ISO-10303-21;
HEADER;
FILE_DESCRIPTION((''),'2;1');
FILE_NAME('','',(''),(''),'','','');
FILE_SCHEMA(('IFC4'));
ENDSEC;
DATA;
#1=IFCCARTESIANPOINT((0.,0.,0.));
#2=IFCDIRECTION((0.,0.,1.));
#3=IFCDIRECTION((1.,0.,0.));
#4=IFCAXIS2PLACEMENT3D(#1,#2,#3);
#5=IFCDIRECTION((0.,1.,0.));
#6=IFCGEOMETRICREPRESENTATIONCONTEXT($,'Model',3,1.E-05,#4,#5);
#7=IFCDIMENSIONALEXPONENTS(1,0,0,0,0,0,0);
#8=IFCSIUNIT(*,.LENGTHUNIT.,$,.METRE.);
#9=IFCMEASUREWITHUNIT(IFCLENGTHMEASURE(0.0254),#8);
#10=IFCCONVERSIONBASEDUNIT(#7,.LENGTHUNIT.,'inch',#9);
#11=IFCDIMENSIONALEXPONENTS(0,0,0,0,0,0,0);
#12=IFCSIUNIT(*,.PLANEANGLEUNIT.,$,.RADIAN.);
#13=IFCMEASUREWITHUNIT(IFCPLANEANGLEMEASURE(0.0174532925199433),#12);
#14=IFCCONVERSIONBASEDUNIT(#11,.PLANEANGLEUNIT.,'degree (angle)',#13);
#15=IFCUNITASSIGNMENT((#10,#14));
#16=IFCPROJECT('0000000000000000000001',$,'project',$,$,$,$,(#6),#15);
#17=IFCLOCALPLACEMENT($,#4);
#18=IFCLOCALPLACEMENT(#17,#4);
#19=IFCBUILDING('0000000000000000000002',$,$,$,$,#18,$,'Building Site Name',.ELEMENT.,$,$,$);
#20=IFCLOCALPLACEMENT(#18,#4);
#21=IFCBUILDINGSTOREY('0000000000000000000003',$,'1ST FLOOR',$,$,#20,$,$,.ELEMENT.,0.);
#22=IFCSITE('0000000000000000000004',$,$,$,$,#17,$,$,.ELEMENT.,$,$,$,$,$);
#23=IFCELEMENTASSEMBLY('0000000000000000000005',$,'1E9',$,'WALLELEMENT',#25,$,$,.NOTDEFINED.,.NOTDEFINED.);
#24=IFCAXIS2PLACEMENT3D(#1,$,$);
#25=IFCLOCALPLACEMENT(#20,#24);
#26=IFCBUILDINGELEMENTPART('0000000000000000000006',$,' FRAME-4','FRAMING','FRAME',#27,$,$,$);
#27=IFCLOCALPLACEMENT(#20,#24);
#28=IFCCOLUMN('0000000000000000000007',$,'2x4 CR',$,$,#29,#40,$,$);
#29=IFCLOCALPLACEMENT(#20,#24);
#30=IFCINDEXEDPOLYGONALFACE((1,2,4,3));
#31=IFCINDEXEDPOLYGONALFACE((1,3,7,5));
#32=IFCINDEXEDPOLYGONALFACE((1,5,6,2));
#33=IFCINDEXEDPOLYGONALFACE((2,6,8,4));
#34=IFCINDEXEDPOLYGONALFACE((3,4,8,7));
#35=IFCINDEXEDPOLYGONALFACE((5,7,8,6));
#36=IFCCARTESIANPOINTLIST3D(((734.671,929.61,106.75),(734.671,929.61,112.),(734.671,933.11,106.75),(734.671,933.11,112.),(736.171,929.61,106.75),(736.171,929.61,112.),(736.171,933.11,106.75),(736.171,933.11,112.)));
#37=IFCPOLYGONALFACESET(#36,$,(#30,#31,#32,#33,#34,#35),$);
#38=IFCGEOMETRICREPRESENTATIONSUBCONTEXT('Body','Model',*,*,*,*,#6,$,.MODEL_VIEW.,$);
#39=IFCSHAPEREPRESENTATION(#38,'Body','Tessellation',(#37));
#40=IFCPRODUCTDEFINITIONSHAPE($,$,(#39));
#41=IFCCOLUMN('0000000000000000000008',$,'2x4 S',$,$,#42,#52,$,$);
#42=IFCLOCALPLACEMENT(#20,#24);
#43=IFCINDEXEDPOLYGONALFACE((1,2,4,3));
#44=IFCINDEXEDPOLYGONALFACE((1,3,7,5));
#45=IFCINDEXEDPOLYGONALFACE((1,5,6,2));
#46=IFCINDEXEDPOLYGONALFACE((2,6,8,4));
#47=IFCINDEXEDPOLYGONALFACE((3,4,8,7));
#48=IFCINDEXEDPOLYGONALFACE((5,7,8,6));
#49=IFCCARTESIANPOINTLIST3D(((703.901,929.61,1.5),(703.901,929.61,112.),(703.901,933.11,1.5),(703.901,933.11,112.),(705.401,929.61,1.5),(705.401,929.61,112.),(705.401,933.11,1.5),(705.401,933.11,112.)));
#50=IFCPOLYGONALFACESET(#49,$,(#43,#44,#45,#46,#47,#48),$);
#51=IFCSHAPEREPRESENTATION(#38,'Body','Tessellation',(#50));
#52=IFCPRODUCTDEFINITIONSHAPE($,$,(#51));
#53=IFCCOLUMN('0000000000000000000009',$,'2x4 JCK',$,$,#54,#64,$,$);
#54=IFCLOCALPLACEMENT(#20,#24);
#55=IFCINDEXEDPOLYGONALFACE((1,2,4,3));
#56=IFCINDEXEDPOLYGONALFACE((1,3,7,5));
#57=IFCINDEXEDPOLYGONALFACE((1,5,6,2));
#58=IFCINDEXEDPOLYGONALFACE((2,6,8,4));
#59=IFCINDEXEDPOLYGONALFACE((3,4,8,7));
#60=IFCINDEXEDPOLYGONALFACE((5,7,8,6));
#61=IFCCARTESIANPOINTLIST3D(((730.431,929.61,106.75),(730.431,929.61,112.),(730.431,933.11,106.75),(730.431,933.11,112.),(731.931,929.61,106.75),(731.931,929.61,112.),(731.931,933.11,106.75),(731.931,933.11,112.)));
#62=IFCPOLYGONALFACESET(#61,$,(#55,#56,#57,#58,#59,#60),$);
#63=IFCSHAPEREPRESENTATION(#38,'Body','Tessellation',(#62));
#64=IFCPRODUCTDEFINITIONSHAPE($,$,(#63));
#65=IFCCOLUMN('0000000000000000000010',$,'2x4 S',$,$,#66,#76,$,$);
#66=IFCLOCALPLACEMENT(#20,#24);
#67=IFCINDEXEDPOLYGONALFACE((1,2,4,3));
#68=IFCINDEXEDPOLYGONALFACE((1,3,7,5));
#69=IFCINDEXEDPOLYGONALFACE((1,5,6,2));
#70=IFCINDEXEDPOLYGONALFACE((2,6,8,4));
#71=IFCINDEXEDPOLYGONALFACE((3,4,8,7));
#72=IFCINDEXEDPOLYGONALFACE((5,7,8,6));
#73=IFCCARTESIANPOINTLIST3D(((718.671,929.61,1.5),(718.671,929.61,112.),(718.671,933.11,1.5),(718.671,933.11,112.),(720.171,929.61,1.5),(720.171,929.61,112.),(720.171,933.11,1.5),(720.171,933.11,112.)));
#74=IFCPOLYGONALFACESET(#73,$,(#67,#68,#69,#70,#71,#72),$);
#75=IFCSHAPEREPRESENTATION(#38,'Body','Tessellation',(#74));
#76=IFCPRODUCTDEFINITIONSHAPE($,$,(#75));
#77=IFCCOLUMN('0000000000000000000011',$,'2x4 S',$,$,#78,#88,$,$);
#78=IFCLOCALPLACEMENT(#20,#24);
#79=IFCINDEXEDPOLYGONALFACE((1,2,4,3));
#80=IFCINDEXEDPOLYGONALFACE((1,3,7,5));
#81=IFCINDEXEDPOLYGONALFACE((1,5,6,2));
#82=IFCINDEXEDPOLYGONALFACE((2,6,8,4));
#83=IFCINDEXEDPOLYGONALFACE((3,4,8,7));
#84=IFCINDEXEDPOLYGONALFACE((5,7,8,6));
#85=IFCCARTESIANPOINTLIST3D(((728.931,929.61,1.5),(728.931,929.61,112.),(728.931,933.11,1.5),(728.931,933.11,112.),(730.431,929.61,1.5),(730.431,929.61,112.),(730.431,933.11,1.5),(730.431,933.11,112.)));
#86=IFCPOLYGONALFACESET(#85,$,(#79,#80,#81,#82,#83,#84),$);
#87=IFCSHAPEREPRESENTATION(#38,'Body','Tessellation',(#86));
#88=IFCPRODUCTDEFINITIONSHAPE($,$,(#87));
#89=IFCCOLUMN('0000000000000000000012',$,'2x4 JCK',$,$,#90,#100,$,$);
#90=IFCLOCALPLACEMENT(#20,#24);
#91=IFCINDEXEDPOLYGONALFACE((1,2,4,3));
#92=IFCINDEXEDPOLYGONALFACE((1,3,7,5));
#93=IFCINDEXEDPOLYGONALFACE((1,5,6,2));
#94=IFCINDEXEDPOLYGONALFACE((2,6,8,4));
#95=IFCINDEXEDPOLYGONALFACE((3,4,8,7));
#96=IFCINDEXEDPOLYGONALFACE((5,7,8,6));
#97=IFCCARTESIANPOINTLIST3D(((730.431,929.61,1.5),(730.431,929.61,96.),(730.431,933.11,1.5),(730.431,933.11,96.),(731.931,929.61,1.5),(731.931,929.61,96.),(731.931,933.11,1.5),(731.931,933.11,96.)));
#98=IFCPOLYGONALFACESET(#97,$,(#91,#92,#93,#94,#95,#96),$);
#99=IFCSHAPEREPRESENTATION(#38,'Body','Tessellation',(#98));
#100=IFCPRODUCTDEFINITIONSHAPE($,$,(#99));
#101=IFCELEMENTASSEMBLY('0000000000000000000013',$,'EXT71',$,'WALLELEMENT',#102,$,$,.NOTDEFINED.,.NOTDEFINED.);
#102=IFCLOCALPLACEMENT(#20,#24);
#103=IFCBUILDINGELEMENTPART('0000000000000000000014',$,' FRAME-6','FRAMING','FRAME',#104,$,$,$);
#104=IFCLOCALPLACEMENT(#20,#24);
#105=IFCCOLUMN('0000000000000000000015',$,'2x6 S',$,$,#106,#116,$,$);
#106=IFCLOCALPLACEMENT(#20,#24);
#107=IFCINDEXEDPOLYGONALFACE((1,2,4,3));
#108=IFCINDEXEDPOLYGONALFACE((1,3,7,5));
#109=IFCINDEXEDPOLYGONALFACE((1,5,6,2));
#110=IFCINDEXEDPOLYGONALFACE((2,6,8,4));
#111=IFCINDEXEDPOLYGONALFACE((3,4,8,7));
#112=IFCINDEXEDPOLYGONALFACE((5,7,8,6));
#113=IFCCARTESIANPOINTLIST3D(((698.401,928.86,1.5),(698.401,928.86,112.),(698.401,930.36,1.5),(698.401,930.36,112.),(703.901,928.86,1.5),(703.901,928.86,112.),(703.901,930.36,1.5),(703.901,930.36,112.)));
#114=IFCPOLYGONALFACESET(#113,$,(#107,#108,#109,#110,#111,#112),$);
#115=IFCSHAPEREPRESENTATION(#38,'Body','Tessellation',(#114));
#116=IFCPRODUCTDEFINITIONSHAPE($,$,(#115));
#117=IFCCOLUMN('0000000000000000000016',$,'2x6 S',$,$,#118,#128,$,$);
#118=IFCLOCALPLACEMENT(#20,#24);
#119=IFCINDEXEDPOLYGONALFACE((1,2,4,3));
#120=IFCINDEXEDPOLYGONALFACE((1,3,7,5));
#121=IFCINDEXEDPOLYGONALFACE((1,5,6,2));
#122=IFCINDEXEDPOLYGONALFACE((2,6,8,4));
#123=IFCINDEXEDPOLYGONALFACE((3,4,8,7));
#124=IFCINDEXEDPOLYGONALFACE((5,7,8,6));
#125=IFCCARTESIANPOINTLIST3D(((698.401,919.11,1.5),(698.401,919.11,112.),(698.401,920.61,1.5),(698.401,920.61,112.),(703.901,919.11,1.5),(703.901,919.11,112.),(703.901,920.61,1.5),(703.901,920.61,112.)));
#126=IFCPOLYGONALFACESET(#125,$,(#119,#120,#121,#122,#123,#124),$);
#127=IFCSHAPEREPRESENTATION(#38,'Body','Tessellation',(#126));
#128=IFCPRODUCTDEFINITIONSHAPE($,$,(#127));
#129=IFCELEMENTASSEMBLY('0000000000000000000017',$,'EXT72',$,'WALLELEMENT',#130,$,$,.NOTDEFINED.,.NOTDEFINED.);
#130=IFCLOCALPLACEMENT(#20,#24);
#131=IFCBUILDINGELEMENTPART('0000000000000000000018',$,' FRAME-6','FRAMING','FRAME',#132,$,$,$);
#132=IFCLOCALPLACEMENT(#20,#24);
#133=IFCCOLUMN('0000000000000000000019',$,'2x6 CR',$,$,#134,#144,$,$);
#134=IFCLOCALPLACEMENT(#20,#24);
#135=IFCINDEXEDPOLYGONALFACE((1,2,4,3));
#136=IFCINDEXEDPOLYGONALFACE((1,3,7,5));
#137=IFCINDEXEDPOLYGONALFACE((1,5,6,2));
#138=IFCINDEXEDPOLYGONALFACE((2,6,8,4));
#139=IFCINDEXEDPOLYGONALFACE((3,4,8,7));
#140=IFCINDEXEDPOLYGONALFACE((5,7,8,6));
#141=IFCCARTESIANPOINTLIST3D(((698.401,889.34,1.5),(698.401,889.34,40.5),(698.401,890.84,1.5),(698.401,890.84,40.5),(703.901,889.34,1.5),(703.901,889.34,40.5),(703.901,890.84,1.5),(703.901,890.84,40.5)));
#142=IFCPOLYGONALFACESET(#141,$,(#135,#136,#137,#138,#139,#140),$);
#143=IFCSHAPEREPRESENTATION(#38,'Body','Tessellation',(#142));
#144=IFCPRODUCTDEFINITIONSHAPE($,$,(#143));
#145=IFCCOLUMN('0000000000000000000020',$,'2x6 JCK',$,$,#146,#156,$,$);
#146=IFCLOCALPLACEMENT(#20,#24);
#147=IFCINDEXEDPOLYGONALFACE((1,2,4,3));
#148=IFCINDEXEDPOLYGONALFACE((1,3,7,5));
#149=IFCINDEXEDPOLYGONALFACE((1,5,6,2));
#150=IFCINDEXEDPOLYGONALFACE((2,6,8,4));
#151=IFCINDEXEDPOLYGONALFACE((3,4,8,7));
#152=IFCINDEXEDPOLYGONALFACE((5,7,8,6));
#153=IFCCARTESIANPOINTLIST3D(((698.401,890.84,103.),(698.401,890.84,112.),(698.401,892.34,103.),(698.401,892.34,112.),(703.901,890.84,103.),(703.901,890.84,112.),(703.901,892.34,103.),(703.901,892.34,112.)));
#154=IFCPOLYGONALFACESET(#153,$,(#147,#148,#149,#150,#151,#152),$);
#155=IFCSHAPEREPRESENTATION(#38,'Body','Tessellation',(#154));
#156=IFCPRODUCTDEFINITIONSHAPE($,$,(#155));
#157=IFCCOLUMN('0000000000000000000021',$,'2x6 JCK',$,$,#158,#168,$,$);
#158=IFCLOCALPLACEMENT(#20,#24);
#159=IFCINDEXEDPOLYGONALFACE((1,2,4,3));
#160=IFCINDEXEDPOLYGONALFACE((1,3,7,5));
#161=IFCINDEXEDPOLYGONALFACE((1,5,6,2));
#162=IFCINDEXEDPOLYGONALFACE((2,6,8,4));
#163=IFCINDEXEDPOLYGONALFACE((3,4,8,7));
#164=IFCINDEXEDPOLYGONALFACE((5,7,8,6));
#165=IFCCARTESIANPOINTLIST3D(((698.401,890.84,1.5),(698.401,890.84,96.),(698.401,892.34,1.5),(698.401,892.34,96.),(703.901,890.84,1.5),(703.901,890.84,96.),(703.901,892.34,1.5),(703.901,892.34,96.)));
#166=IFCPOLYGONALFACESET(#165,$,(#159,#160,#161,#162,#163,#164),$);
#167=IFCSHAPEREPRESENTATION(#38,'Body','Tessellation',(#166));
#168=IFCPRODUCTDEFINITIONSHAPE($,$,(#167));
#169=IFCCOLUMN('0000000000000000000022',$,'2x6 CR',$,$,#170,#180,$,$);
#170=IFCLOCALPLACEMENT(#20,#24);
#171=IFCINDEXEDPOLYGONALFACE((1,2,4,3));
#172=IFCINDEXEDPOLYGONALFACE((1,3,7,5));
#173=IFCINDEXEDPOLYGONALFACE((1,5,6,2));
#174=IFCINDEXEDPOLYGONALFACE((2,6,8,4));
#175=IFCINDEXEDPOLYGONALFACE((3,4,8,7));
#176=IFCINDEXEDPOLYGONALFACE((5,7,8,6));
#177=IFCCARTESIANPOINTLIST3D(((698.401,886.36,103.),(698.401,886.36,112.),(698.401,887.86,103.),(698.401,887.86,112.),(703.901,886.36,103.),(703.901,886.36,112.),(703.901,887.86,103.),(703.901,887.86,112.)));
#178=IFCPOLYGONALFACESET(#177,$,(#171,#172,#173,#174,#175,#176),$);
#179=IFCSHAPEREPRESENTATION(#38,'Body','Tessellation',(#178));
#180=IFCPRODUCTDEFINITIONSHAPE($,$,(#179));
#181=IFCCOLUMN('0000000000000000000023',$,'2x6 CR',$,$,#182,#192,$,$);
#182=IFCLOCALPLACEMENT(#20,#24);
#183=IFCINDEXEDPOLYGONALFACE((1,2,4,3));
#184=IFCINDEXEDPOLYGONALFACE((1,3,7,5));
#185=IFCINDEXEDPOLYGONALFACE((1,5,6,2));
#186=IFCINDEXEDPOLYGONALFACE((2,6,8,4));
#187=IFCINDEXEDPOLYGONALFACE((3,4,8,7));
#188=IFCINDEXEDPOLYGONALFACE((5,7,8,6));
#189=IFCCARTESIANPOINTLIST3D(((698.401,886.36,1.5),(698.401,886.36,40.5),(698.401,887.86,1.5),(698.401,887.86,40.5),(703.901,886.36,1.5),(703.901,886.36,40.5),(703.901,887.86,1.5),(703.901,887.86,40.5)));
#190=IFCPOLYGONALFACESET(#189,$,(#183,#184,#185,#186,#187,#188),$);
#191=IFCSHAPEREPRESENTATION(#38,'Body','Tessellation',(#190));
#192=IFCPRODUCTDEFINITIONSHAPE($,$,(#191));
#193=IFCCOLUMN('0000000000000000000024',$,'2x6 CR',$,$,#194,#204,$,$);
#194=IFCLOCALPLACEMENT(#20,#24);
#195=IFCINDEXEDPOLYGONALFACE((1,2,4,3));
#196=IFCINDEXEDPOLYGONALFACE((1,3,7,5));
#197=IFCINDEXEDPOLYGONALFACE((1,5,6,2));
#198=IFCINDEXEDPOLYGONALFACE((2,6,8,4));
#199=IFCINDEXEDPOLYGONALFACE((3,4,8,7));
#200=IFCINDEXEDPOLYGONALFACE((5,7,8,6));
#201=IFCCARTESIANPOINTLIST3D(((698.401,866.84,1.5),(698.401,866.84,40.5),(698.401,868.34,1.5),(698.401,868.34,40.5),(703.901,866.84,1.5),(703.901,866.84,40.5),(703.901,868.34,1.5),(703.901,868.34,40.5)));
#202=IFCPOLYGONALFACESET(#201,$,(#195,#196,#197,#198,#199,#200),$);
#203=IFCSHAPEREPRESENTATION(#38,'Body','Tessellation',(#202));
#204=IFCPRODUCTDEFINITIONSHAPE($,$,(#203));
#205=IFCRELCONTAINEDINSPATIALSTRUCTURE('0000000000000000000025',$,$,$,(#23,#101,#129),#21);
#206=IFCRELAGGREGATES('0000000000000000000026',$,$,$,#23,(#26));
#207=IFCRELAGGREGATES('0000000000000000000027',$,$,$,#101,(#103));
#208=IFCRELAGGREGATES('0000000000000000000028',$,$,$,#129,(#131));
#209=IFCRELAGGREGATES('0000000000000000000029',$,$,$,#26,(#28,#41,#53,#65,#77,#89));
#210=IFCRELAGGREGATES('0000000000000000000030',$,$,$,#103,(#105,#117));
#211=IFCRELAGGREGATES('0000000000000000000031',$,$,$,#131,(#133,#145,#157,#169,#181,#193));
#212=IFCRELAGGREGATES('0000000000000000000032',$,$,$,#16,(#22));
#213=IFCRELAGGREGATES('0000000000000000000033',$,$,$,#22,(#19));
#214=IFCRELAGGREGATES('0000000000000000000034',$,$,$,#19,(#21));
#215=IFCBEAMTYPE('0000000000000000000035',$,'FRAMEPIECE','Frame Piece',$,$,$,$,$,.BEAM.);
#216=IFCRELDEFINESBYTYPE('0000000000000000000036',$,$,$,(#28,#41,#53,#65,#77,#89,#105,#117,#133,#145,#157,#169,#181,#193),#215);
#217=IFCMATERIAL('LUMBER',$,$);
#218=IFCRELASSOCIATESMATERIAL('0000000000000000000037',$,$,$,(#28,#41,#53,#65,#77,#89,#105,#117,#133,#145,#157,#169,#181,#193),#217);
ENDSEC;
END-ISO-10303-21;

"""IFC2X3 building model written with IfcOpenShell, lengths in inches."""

from ifc_helpers import new_model, entity, si_unit, converted_unit, direction, frame, frame_2d, origin_with_axes, place, context, subcontext, project, spatial, rectangle, extrude, material, type_object, element, aggregate, save


model = new_model("IFC2X3")

# Units and contexts
model_context = context("Model", 3, precision=1e-05, world=origin_with_axes(), true_north=direction((0.0, 1.0, 0.0)))
body_context = subcontext(model_context, "Body", "Model", "MODEL_VIEW")
ifc_project = project(units=[converted_unit("LENGTHUNIT", "inch", entity("IfcLengthMeasure", 0.0254), si_unit("LENGTHUNIT", "METRE"), dimensions=[1, 0, 0, 0, 0, 0, 0]), converted_unit("PLANEANGLEUNIT", "degree (angle)", entity("IfcPlaneAngleMeasure", 0.0174532925199433), si_unit("PLANEANGLEUNIT", "RADIAN"), dimensions=[0, 0, 0, 0, 0, 0, 0])], contexts=[model_context])

# Site, building, storey
site_placement = place(None, origin_with_axes())
site = spatial("IfcSite", under=ifc_project, at=site_placement, CompositionType="ELEMENT")
building_placement = place(site_placement, origin_with_axes())
building = spatial("IfcBuilding", under=site, at=building_placement, LongName="Building Site Name", CompositionType="ELEMENT")
storey_placement = place(building_placement, origin_with_axes())
storey = spatial("IfcBuildingStorey", under=building, at=storey_placement, Name="1ST FLOOR", CompositionType="ELEMENT", Elevation=0.0)

# Element assemblies, building element parts, columns
assembly_1_placement = place(storey_placement, origin_with_axes())
assembly_1 = element("IfcElementAssembly", 1, at=assembly_1_placement, inside=storey, Name="1E9", ObjectType="WALLELEMENT", AssemblyPlace="NOTDEFINED", PredefinedType="NOTDEFINED")
building_element_part_1 = element("IfcBuildingElementPart", 2, Name=" FRAME-4", Description="FRAMING", ObjectType="FRAME")
aggregate(assembly_1, [building_element_part_1])
ifc_material_1 = material(Name="LUMBER")
beam_type = type_object("IfcBeamType", Name="FRAMEPIECE", Description="Frame Piece", PredefinedType="BEAM")
column_1_placement = place(assembly_1_placement, frame((735.421, 931.36, 112.0), z_axis=(0.0, 0.0, -1.0), x_axis=(-1.0, 0.0, 0.0)))
column_1 = element("IfcColumn", 3, at=column_1_placement, type_object=beam_type, material=ifc_material_1, Name="2x4 CR", context=body_context, shape_type="SweptSolid", body=[
    extrude(rectangle(XDim=1.5, YDim=3.5, at=frame_2d((0.0, 0.0), x_axis=(-1.0, 0.0))), origin_with_axes(), (0.0, 0.0, 1.0), 5.25),
])
column_2_placement = place(assembly_1_placement, frame((704.651, 931.36, 1.5), z_axis=(0.0, 0.0, 1.0), x_axis=(1.0, 0.0, 0.0)))
column_2 = element("IfcColumn", 4, at=column_2_placement, type_object=beam_type, material=ifc_material_1, Name="2x4 S", context=body_context, shape_type="SweptSolid", body=[
    extrude(rectangle(XDim=1.5, YDim=3.5, at=frame_2d((0.0, 0.0), x_axis=(-1.0, 0.0))), frame((0.0, 0.0, 0.0), z_axis=(0.0, 0.0, 1.0), x_axis=(1.0, 0.0, 0.0)), (0.0, 0.0, 1.0), 110.5),
])
column_3_placement = place(assembly_1_placement, frame((731.181, 931.36, 106.75), z_axis=(0.0, 0.0, 1.0), x_axis=(1.0, 0.0, 0.0)))
column_3 = element("IfcColumn", 5, at=column_3_placement, type_object=beam_type, material=ifc_material_1, Name="2x4 JCK", context=body_context, shape_type="SweptSolid", body=[
    extrude(rectangle(XDim=1.5, YDim=3.5, at=frame_2d((0.0, 0.0), x_axis=(-1.0, 0.0))), origin_with_axes(), (0.0, 0.0, 1.0), 5.25),
])
column_4_placement = place(assembly_1_placement, frame((719.421, 931.36, 112.0), z_axis=(0.0, 0.0, -1.0), x_axis=(-1.0, 0.0, 0.0)))
column_4 = element("IfcColumn", 6, at=column_4_placement, type_object=beam_type, material=ifc_material_1, Name="2x4 S", context=body_context, shape_type="SweptSolid", body=[
    extrude(rectangle(XDim=1.5, YDim=3.5, at=frame_2d((0.0, 0.0), x_axis=(-1.0, 0.0))), origin_with_axes(), (0.0, 0.0, 1.0), 110.5),
])
column_5_placement = place(assembly_1_placement, frame((729.681, 931.36, 1.5), z_axis=(0.0, 0.0, 1.0), x_axis=(1.0, 0.0, 0.0)))
column_5 = element("IfcColumn", 7, at=column_5_placement, type_object=beam_type, material=ifc_material_1, Name="2x4 S", context=body_context, shape_type="SweptSolid", body=[
    extrude(rectangle(XDim=1.5, YDim=3.5, at=frame_2d((0.0, 0.0), x_axis=(-1.0, 0.0))), frame((0.0, 0.0, 0.0), z_axis=(0.0, 0.0, 1.0), x_axis=(1.0, 0.0, 0.0)), (0.0, 0.0, 1.0), 110.5),
])
column_6_placement = place(assembly_1_placement, frame((731.181, 931.36, 1.5), z_axis=(0.0, 0.0, 1.0), x_axis=(1.0, 0.0, 0.0)))
column_6 = element("IfcColumn", 8, at=column_6_placement, type_object=beam_type, material=ifc_material_1, Name="2x4 JCK", context=body_context, shape_type="SweptSolid", body=[
    extrude(rectangle(XDim=1.5, YDim=3.5, at=frame_2d((0.0, 0.0), x_axis=(-1.0, 0.0))), frame((0.0, 0.0, 0.0), z_axis=(0.0, 0.0, 1.0), x_axis=(1.0, 0.0, 0.0)), (0.0, 0.0, 1.0), 94.5),
])
assembly_2_placement = place(storey_placement, origin_with_axes())
assembly_2 = element("IfcElementAssembly", 9, at=assembly_2_placement, inside=storey, Name="EXT71", ObjectType="WALLELEMENT", AssemblyPlace="NOTDEFINED", PredefinedType="NOTDEFINED")
building_element_part_2 = element("IfcBuildingElementPart", 10, Name=" FRAME-6", Description="FRAMING", ObjectType="FRAME")
aggregate(assembly_2, [building_element_part_2])
column_7_placement = place(assembly_2_placement, frame((701.151, 929.61, 112.0), z_axis=(0.0, 0.0, -1.0), x_axis=(0.0, -1.0, 0.0)))
column_7 = element("IfcColumn", 11, at=column_7_placement, type_object=beam_type, material=ifc_material_1, Name="2x6 S", context=body_context, shape_type="SweptSolid", body=[
    extrude(rectangle(XDim=1.5, YDim=5.5, at=frame_2d((0.0, 0.0), x_axis=(-1.0, 0.0))), origin_with_axes(), (0.0, 0.0, 1.0), 110.5),
])
column_8_placement = place(assembly_2_placement, frame((701.151, 919.86, 1.5), z_axis=(0.0, 0.0, 1.0), x_axis=(0.0, 1.0, 0.0)))
column_8 = element("IfcColumn", 12, at=column_8_placement, type_object=beam_type, material=ifc_material_1, Name="2x6 S", context=body_context, shape_type="SweptSolid", body=[
    extrude(rectangle(XDim=1.5, YDim=5.5, at=frame_2d((0.0, 0.0), x_axis=(-1.0, 0.0))), frame((0.0, 0.0, 0.0), z_axis=(0.0, 0.0, 1.0), x_axis=(1.0, 0.0, 0.0)), (0.0, 0.0, 1.0), 110.5),
])
assembly_3_placement = place(storey_placement, origin_with_axes())
assembly_3 = element("IfcElementAssembly", 13, at=assembly_3_placement, inside=storey, Name="EXT72", ObjectType="WALLELEMENT", AssemblyPlace="NOTDEFINED", PredefinedType="NOTDEFINED")
building_element_part_3 = element("IfcBuildingElementPart", 14, Name=" FRAME-6", Description="FRAMING", ObjectType="FRAME")
aggregate(assembly_3, [building_element_part_3])
column_9_placement = place(assembly_3_placement, frame((701.151, 890.09, 40.5), z_axis=(0.0, 0.0, -1.0), x_axis=(0.0, -1.0, 0.0)))
column_9 = element("IfcColumn", 15, at=column_9_placement, type_object=beam_type, material=ifc_material_1, Name="2x6 CR", context=body_context, shape_type="SweptSolid", body=[
    extrude(rectangle(XDim=1.5, YDim=5.5, at=frame_2d((0.0, 0.0), x_axis=(-1.0, 0.0))), origin_with_axes(), (0.0, 0.0, 1.0), 39.0),
])
column_10_placement = place(assembly_3_placement, frame((701.151, 891.59, 112.0), z_axis=(0.0, 0.0, -1.0), x_axis=(0.0, -1.0, 0.0)))
column_10 = element("IfcColumn", 16, at=column_10_placement, type_object=beam_type, material=ifc_material_1, Name="2x6 JCK", context=body_context, shape_type="SweptSolid", body=[
    extrude(rectangle(XDim=1.5, YDim=5.5, at=frame_2d((0.0, 0.0), x_axis=(-1.0, 0.0))), origin_with_axes(), (0.0, 0.0, 1.0), 9.0),
])
column_11_placement = place(assembly_3_placement, frame((701.151, 891.59, 96.0), z_axis=(0.0, 0.0, -1.0), x_axis=(0.0, -1.0, 0.0)))
column_11 = element("IfcColumn", 17, at=column_11_placement, type_object=beam_type, material=ifc_material_1, Name="2x6 JCK", context=body_context, shape_type="SweptSolid", body=[
    extrude(rectangle(XDim=1.5, YDim=5.5, at=frame_2d((0.0, 0.0), x_axis=(-1.0, 0.0))), origin_with_axes(), (0.0, 0.0, 1.0), 94.5),
])
column_12_placement = place(assembly_3_placement, frame((701.151, 887.11, 112.0), z_axis=(0.0, 0.0, -1.0), x_axis=(0.0, -1.0, 0.0)))
column_12 = element("IfcColumn", 18, at=column_12_placement, type_object=beam_type, material=ifc_material_1, Name="2x6 CR", context=body_context, shape_type="SweptSolid", body=[
    extrude(rectangle(XDim=1.5, YDim=5.5, at=frame_2d((0.0, 0.0), x_axis=(-1.0, 0.0))), origin_with_axes(), (0.0, 0.0, 1.0), 9.0),
])
column_13_placement = place(assembly_3_placement, frame((701.151, 887.11, 40.5), z_axis=(0.0, 0.0, -1.0), x_axis=(0.0, -1.0, 0.0)))
column_13 = element("IfcColumn", 19, at=column_13_placement, type_object=beam_type, material=ifc_material_1, Name="2x6 CR", context=body_context, shape_type="SweptSolid", body=[
    extrude(rectangle(XDim=1.5, YDim=5.5, at=frame_2d((0.0, 0.0), x_axis=(-1.0, 0.0))), origin_with_axes(), (0.0, 0.0, 1.0), 39.0),
])
column_14_placement = place(assembly_3_placement, frame((701.151, 867.59, 1.5), z_axis=(0.0, 0.0, 1.0), x_axis=(0.0, 1.0, 0.0)))
column_14 = element("IfcColumn", 20, at=column_14_placement, type_object=beam_type, material=ifc_material_1, Name="2x6 CR", context=body_context, shape_type="SweptSolid", body=[
    extrude(rectangle(XDim=1.5, YDim=5.5, at=frame_2d((0.0, 0.0), x_axis=(-1.0, 0.0))), frame((0.0, 0.0, 0.0), z_axis=(0.0, 0.0, 1.0), x_axis=(1.0, 0.0, 0.0)), (0.0, 0.0, 1.0), 39.0),
])

aggregate(building_element_part_1, [column_1, column_2, column_3, column_4, column_5, column_6])
aggregate(building_element_part_2, [column_7, column_8])
aggregate(building_element_part_3, [column_9, column_10, column_11, column_12, column_13, column_14])

save(model, "model.ifc")
